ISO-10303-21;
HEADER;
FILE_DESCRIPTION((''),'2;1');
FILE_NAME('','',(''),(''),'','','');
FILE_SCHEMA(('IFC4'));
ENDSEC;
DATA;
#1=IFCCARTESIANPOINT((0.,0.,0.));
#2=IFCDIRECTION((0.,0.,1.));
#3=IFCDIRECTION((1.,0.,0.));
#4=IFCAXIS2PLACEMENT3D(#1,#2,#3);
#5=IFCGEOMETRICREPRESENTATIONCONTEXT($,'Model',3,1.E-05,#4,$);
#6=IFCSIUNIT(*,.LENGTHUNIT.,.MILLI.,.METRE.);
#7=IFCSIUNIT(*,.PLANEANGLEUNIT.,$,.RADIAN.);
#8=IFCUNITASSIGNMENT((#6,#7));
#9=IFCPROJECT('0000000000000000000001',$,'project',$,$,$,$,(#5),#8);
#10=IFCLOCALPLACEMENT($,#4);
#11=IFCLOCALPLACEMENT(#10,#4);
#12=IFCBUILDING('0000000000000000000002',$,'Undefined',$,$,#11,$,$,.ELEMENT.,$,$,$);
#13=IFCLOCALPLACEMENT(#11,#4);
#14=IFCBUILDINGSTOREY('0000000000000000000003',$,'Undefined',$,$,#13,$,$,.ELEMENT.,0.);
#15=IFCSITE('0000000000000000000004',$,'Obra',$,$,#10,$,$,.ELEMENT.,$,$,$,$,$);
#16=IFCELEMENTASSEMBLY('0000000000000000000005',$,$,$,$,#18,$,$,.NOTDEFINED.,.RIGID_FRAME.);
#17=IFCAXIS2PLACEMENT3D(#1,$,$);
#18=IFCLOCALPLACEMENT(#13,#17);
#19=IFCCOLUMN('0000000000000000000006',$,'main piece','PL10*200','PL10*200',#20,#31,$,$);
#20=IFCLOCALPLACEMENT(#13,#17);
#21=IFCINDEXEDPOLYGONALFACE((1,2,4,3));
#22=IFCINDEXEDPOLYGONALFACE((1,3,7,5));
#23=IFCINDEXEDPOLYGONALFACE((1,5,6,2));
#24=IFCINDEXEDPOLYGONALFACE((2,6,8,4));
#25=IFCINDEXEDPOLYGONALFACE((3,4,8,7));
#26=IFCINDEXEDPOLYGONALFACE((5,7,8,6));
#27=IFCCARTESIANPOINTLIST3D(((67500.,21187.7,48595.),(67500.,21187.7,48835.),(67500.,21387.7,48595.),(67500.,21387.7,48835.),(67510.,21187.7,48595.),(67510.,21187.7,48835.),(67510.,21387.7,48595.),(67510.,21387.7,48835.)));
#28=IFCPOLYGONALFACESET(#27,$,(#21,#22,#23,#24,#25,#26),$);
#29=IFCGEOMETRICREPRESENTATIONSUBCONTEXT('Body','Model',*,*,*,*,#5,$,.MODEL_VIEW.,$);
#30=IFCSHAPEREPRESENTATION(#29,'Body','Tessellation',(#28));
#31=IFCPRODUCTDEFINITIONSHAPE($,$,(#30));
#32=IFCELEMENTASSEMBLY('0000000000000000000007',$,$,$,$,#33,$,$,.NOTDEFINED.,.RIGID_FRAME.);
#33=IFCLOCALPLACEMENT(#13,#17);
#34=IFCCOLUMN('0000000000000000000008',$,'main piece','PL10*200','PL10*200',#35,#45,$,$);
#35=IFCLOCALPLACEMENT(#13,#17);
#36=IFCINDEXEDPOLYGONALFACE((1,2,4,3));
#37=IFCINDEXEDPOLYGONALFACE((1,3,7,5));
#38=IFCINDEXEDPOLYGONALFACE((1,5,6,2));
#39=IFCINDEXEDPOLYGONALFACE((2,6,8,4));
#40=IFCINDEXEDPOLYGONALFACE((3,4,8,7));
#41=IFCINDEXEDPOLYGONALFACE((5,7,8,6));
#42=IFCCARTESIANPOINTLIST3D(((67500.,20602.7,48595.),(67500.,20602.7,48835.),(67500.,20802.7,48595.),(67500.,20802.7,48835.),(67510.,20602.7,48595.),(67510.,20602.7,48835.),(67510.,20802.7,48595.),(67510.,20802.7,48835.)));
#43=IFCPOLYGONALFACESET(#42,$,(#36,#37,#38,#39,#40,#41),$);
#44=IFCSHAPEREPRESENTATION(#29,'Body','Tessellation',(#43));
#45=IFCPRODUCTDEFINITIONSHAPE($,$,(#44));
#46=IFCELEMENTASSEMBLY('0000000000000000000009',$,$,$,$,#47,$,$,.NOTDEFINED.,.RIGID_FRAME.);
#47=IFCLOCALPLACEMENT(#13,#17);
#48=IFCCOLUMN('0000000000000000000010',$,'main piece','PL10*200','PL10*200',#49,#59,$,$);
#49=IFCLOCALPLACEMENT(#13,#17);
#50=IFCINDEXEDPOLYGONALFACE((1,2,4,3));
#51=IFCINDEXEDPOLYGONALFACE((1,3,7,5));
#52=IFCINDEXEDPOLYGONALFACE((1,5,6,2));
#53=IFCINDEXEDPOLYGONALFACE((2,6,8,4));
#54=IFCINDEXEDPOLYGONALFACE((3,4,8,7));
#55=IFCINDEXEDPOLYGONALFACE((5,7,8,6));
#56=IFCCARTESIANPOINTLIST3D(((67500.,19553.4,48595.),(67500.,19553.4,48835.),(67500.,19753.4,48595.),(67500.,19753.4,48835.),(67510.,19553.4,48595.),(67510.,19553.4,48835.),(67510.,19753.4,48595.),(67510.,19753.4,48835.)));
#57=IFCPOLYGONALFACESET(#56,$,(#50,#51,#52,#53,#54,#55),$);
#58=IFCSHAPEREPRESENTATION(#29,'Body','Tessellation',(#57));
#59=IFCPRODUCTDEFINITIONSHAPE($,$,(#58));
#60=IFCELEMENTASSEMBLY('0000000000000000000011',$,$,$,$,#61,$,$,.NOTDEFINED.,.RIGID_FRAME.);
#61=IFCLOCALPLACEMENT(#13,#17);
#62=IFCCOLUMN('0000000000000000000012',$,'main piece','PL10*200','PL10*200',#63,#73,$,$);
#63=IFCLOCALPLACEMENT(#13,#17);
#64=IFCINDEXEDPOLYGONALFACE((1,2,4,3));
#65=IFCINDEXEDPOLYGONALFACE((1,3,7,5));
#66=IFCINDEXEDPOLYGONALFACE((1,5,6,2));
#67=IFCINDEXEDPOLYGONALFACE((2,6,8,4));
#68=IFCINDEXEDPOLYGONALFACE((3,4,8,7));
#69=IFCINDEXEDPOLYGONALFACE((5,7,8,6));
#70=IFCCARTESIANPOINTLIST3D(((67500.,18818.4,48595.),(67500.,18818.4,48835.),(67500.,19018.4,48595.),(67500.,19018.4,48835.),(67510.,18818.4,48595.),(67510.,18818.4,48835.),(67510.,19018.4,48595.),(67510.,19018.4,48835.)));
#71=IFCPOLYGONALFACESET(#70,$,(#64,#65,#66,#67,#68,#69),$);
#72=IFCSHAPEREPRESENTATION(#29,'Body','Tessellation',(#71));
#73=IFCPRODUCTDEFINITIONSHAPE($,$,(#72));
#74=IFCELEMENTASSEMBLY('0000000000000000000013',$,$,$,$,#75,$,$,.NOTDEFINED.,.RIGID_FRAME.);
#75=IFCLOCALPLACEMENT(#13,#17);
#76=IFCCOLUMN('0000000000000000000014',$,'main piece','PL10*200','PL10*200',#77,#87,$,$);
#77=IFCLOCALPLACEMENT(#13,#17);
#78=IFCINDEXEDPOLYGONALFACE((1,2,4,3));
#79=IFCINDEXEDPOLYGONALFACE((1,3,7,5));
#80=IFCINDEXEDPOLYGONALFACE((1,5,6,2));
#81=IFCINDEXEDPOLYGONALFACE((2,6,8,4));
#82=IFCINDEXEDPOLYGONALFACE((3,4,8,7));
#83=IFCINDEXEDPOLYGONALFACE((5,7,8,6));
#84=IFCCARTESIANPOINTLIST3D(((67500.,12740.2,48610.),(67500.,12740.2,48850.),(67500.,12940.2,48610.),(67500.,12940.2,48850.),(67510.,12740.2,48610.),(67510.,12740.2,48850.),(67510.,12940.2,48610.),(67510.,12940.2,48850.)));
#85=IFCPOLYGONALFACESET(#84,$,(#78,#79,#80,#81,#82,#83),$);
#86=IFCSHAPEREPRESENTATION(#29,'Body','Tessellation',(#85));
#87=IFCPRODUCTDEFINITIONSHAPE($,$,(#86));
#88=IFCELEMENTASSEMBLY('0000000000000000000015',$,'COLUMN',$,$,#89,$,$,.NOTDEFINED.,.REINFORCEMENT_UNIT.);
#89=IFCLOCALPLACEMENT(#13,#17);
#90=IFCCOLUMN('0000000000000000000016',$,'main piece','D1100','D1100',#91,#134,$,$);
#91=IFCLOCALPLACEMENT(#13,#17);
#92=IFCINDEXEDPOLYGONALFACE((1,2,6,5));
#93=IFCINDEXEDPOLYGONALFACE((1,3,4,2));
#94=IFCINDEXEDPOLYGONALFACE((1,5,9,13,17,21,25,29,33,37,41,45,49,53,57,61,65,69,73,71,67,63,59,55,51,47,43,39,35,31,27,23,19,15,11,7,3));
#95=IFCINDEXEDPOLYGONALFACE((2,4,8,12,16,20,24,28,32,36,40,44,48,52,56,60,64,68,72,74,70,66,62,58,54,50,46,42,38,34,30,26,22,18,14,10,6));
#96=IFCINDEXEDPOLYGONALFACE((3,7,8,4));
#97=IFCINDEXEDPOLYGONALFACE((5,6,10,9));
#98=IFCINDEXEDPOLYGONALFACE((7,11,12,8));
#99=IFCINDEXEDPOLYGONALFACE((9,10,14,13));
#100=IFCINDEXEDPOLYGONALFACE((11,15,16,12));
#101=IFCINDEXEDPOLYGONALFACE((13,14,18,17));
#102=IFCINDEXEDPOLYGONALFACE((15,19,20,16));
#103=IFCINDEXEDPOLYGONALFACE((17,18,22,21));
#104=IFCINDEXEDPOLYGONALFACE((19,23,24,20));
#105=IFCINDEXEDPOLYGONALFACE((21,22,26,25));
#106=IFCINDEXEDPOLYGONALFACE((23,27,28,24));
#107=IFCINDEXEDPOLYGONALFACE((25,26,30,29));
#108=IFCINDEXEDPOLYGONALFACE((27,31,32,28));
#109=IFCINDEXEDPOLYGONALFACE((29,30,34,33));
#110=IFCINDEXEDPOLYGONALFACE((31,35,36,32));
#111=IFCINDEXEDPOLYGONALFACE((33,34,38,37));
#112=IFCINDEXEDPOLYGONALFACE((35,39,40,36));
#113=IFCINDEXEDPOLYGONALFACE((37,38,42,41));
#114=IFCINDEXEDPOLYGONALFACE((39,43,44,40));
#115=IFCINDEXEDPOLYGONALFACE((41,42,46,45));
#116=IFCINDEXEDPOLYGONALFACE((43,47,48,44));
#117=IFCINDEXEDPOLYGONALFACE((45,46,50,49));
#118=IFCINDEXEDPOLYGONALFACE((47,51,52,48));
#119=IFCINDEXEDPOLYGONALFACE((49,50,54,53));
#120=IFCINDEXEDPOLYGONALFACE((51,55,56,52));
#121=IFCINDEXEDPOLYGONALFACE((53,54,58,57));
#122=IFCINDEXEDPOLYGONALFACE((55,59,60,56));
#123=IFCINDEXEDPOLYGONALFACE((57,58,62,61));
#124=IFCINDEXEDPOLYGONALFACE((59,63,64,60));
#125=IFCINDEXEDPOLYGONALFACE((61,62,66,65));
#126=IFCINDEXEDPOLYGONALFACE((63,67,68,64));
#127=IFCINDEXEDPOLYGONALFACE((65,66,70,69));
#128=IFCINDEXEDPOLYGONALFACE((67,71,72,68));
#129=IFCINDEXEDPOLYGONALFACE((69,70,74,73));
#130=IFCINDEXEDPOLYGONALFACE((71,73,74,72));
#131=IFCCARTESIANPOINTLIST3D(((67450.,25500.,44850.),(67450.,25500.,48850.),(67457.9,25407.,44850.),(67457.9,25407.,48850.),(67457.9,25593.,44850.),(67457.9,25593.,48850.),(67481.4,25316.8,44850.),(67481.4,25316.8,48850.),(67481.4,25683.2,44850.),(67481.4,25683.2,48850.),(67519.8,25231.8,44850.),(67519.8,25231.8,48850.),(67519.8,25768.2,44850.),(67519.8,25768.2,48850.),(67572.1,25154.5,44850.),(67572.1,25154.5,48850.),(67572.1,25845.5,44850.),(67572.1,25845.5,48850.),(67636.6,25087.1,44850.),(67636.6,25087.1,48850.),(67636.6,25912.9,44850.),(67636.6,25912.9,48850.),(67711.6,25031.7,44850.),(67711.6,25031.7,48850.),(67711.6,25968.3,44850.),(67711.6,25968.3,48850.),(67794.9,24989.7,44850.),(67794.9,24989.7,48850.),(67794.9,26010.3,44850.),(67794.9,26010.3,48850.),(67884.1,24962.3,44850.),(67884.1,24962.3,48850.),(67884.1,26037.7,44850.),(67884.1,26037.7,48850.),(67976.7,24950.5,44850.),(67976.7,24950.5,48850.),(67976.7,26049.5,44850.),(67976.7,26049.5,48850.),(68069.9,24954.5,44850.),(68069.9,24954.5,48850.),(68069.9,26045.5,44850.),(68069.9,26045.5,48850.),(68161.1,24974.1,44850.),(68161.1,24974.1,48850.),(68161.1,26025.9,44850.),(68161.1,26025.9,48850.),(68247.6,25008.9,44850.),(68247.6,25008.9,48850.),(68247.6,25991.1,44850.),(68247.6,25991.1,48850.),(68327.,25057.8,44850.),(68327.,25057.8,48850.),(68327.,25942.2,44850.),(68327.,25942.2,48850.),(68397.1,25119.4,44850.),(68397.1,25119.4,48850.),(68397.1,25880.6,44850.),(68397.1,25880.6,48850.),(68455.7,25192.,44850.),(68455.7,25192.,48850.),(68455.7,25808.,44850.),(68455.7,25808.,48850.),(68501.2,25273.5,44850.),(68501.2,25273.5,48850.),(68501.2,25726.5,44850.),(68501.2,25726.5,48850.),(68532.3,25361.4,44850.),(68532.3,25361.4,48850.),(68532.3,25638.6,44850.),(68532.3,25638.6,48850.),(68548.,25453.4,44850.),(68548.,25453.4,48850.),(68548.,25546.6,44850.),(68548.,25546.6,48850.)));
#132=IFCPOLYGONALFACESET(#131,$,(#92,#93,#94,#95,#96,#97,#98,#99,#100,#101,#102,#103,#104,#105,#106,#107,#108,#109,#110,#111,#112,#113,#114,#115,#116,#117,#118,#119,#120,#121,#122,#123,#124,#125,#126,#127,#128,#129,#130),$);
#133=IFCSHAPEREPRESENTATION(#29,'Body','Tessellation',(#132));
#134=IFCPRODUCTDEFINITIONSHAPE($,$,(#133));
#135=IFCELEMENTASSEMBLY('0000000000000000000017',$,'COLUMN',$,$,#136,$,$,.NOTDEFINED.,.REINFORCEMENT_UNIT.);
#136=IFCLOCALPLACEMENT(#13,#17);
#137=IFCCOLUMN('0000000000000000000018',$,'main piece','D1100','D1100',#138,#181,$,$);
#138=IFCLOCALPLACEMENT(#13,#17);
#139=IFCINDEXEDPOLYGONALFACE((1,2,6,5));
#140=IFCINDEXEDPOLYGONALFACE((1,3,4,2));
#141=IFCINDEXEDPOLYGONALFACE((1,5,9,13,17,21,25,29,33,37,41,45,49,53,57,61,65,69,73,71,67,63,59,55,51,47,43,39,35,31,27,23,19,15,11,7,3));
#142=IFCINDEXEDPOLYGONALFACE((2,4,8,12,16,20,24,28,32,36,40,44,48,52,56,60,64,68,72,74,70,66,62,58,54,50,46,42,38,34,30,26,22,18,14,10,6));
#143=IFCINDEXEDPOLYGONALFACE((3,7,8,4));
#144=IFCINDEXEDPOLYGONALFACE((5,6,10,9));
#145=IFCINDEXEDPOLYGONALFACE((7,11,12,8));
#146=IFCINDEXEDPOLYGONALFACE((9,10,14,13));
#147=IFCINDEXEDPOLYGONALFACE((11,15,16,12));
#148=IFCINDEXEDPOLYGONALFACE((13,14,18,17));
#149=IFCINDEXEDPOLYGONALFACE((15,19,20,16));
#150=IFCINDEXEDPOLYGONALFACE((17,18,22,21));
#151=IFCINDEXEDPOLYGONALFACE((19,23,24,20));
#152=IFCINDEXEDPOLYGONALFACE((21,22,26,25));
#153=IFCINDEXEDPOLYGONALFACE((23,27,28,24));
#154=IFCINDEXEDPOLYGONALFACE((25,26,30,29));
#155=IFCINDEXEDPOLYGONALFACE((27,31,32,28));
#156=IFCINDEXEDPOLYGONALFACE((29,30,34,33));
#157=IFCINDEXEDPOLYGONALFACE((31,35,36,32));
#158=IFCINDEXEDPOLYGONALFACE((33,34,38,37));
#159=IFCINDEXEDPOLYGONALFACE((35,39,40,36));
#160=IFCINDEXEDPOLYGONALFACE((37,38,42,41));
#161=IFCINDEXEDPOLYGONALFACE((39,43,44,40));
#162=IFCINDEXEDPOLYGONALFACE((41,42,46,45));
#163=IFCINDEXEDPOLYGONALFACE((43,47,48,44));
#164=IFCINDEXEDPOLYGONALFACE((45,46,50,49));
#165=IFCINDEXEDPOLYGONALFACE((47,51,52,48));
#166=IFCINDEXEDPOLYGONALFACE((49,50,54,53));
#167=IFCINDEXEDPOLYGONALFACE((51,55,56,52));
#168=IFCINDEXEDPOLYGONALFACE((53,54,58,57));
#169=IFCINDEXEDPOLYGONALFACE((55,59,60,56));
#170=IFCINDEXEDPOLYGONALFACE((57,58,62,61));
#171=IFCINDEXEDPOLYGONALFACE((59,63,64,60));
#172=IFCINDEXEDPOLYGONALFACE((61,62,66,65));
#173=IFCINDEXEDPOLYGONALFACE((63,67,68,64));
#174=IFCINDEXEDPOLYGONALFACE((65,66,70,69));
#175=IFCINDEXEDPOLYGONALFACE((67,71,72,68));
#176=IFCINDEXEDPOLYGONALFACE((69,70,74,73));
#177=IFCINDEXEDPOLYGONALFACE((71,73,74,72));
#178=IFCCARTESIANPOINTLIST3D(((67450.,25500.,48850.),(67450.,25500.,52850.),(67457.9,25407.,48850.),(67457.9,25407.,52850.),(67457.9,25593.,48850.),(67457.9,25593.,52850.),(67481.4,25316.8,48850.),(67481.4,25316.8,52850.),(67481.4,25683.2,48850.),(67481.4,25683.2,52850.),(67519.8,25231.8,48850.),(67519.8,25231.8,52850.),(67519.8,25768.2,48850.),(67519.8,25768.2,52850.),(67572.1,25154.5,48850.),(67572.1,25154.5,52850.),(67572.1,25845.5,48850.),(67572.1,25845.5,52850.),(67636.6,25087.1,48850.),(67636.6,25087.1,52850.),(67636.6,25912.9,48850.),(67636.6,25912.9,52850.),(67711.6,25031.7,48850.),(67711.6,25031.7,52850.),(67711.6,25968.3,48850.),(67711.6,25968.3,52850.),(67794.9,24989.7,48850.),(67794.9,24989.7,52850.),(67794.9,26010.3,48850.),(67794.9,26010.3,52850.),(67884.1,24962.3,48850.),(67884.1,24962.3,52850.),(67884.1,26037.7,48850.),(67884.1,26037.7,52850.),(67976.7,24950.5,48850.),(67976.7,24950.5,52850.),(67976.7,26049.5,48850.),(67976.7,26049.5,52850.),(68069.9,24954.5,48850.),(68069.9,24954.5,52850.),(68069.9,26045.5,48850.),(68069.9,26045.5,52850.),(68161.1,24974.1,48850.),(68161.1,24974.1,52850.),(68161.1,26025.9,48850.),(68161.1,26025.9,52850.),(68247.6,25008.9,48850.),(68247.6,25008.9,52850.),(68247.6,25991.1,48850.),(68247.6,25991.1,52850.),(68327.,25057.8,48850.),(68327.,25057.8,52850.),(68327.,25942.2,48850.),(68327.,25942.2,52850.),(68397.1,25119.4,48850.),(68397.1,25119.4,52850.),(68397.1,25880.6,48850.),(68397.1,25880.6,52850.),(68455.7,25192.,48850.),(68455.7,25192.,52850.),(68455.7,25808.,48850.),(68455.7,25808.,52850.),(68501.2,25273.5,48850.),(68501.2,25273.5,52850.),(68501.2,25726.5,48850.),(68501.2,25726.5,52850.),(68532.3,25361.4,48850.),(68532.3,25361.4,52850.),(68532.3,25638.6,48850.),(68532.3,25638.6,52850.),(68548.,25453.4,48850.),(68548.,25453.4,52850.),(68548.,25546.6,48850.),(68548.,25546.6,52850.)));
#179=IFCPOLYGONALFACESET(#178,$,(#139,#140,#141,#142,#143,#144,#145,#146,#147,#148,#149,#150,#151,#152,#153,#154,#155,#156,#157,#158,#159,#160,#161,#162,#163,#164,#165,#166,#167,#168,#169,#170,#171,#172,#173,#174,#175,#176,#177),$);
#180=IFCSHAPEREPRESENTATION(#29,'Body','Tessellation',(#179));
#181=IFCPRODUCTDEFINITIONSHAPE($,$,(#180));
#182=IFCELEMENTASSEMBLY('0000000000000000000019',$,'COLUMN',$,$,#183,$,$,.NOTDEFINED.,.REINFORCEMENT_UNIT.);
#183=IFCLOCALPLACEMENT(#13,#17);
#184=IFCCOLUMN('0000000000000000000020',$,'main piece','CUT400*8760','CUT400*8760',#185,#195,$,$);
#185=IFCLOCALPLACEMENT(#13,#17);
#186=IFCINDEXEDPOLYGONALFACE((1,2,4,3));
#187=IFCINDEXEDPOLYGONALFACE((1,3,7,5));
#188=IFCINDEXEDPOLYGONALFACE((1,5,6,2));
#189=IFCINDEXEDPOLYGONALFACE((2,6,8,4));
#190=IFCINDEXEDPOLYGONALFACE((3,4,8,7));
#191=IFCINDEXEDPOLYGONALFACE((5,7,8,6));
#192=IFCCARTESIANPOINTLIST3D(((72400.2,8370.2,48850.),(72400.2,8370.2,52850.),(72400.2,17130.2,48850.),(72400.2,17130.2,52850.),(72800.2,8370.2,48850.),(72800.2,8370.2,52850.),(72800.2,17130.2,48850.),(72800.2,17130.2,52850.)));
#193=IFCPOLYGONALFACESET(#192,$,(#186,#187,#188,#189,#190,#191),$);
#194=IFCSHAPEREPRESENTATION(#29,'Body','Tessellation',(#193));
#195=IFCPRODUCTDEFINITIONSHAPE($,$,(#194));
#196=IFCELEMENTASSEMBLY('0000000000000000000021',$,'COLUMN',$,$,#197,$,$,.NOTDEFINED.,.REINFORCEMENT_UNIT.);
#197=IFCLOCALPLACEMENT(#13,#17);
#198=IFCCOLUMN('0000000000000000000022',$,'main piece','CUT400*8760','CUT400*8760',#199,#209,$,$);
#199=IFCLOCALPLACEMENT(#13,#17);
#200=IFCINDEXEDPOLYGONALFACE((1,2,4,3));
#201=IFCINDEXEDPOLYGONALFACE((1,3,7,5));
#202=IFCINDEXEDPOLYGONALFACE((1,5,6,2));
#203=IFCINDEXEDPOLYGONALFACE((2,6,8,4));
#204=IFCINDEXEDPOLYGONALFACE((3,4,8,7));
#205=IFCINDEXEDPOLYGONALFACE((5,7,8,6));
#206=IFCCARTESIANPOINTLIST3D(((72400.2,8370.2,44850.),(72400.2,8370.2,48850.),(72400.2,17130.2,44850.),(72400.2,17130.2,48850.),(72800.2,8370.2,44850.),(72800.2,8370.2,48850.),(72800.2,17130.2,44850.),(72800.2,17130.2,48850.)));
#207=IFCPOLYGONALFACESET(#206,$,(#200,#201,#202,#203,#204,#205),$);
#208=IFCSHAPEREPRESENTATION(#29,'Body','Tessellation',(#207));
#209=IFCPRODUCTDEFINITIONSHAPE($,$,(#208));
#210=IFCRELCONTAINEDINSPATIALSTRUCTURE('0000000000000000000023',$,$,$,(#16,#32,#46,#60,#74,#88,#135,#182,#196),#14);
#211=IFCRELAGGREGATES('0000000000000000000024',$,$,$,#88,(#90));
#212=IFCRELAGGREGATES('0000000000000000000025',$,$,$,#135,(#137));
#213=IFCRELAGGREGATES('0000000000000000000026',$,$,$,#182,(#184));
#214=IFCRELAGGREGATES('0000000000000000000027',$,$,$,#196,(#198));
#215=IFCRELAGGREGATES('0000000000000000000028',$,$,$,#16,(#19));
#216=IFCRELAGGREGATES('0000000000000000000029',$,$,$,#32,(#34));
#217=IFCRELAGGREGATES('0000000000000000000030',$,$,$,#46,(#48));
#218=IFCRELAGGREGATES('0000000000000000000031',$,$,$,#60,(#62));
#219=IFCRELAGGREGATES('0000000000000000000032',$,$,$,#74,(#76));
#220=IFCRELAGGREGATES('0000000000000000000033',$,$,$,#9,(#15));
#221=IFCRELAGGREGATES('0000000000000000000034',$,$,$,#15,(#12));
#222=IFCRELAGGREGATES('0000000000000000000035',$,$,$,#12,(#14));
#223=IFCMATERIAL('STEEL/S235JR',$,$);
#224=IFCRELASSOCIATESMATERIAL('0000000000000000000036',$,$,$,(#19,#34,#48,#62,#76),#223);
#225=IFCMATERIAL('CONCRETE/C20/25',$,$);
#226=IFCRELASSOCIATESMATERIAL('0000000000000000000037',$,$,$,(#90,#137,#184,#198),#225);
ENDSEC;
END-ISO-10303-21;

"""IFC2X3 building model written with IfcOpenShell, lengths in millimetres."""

from ifc_helpers import new_model, si_unit, frame, origin_with_axes, origin_2d_with_axis, place, context, subcontext, project, spatial, rectangle, circle, extrude, material, element, aggregate, save


model = new_model("IFC2X3")

# Units and contexts
model_context = context("Model", 3, precision=1e-05, world=origin_with_axes())
body_context = subcontext(model_context, "Body", "Model", "MODEL_VIEW")
ifc_project = project(units=[si_unit("LENGTHUNIT", "METRE", prefix="MILLI"), si_unit("PLANEANGLEUNIT", "RADIAN")], contexts=[model_context])

# Site, building, storey
site_placement = place(None, origin_with_axes())
site = spatial("IfcSite", under=ifc_project, at=site_placement, Name="Obra", CompositionType="ELEMENT")
building_placement = place(site_placement, origin_with_axes())
building = spatial("IfcBuilding", under=site, at=building_placement, Name="Undefined", CompositionType="ELEMENT")
storey_placement = place(building_placement, origin_with_axes())
storey = spatial("IfcBuildingStorey", under=building, at=storey_placement, Name="Undefined", CompositionType="ELEMENT", Elevation=0.0)

# Element assemblies, columns
assembly_1_placement = place(storey_placement, origin_with_axes())
assembly_1 = element("IfcElementAssembly", 1, at=assembly_1_placement, inside=storey, AssemblyPlace="NOTDEFINED", PredefinedType="RIGID_FRAME")
ifc_material_1 = material(Name="STEEL/S235JR")
column_1_placement = place(assembly_1_placement, frame((67505.0, 21287.7, 48595.0), z_axis=(0.0, 0.0, 1.0), x_axis=(0.0, 1.0, 0.0)))
column_1 = element("IfcColumn", 2, at=column_1_placement, material=ifc_material_1, Name="main piece", Description="PL10*200", ObjectType="PL10*200", context=body_context, shape_type="SweptSolid", body=[
    extrude(rectangle(XDim=10.0, YDim=200.0, at=origin_2d_with_axis()), frame((0.0, 0.0, 240.0), z_axis=(0.0, 0.0, -1.0), x_axis=(0.0, 1.0, 0.0)), (0.0, 0.0, 1.0), 240.0),
])
assembly_2_placement = place(storey_placement, origin_with_axes())
assembly_2 = element("IfcElementAssembly", 3, at=assembly_2_placement, inside=storey, AssemblyPlace="NOTDEFINED", PredefinedType="RIGID_FRAME")
column_2_placement = place(assembly_2_placement, frame((67505.0, 20702.7, 48595.0), z_axis=(0.0, 0.0, 1.0), x_axis=(0.0, 1.0, 0.0)))
column_2 = element("IfcColumn", 4, at=column_2_placement, material=ifc_material_1, Name="main piece", Description="PL10*200", ObjectType="PL10*200", context=body_context, shape_type="SweptSolid", body=[
    extrude(rectangle(XDim=10.0, YDim=200.0, at=origin_2d_with_axis()), frame((0.0, 0.0, 240.0), z_axis=(0.0, 0.0, -1.0), x_axis=(0.0, 1.0, 0.0)), (0.0, 0.0, 1.0), 240.0),
])
assembly_3_placement = place(storey_placement, origin_with_axes())
assembly_3 = element("IfcElementAssembly", 5, at=assembly_3_placement, inside=storey, AssemblyPlace="NOTDEFINED", PredefinedType="RIGID_FRAME")
column_3_placement = place(assembly_3_placement, frame((67505.0, 19653.4, 48595.0), z_axis=(0.0, 0.0, 1.0), x_axis=(0.0, 1.0, 0.0)))
column_3 = element("IfcColumn", 6, at=column_3_placement, material=ifc_material_1, Name="main piece", Description="PL10*200", ObjectType="PL10*200", context=body_context, shape_type="SweptSolid", body=[
    extrude(rectangle(XDim=10.0, YDim=200.0, at=origin_2d_with_axis()), frame((0.0, 0.0, 240.0), z_axis=(0.0, 0.0, -1.0), x_axis=(0.0, 1.0, 0.0)), (0.0, 0.0, 1.0), 240.0),
])
assembly_4_placement = place(storey_placement, origin_with_axes())
assembly_4 = element("IfcElementAssembly", 7, at=assembly_4_placement, inside=storey, AssemblyPlace="NOTDEFINED", PredefinedType="RIGID_FRAME")
column_4_placement = place(assembly_4_placement, frame((67505.0, 18918.4, 48595.0), z_axis=(0.0, 0.0, 1.0), x_axis=(0.0, 1.0, 0.0)))
column_4 = element("IfcColumn", 8, at=column_4_placement, material=ifc_material_1, Name="main piece", Description="PL10*200", ObjectType="PL10*200", context=body_context, shape_type="SweptSolid", body=[
    extrude(rectangle(XDim=10.0, YDim=200.0, at=origin_2d_with_axis()), frame((0.0, 0.0, 240.0), z_axis=(0.0, 0.0, -1.0), x_axis=(0.0, 1.0, 0.0)), (0.0, 0.0, 1.0), 240.0),
])
assembly_5_placement = place(storey_placement, origin_with_axes())
assembly_5 = element("IfcElementAssembly", 9, at=assembly_5_placement, inside=storey, AssemblyPlace="NOTDEFINED", PredefinedType="RIGID_FRAME")
column_5_placement = place(assembly_5_placement, frame((67505.0, 12840.2, 48610.0), z_axis=(0.0, 0.0, 1.0), x_axis=(0.0, 1.0, 0.0)))
column_5 = element("IfcColumn", 10, at=column_5_placement, material=ifc_material_1, Name="main piece", Description="PL10*200", ObjectType="PL10*200", context=body_context, shape_type="SweptSolid", body=[
    extrude(rectangle(XDim=10.0, YDim=200.0, at=origin_2d_with_axis()), frame((0.0, 0.0, 240.0), z_axis=(0.0, 0.0, -1.0), x_axis=(0.0, 1.0, 0.0)), (0.0, 0.0, 1.0), 240.0),
])
assembly_6_placement = place(storey_placement, origin_with_axes())
assembly_6 = element("IfcElementAssembly", 11, at=assembly_6_placement, inside=storey, Name="COLUMN", AssemblyPlace="NOTDEFINED", PredefinedType="REINFORCEMENT_UNIT")
ifc_material_2 = material(Name="CONCRETE/C20/25")
column_6_placement = place(assembly_6_placement, frame((68000.0, 25500.0, 44850.0), z_axis=(0.0, 0.0, 1.0), x_axis=(0.0, 1.0, 0.0)))
column_6 = element("IfcColumn", 12, at=column_6_placement, material=ifc_material_2, Name="main piece", Description="D1100", ObjectType="D1100", context=body_context, shape_type="SweptSolid", body=[
    extrude(circle(Radius=550.0, at=origin_2d_with_axis()), frame((0.0, 0.0, 4000.0), z_axis=(0.0, 0.0, -1.0), x_axis=(0.0, 1.0, 0.0)), (0.0, 0.0, 1.0), 4000.0),
])
aggregate(assembly_6, [column_6])
assembly_7_placement = place(storey_placement, origin_with_axes())
assembly_7 = element("IfcElementAssembly", 13, at=assembly_7_placement, inside=storey, Name="COLUMN", AssemblyPlace="NOTDEFINED", PredefinedType="REINFORCEMENT_UNIT")
column_7_placement = place(assembly_7_placement, frame((68000.0, 25500.0, 48850.0), z_axis=(0.0, 0.0, 1.0), x_axis=(0.0, 1.0, 0.0)))
column_7 = element("IfcColumn", 14, at=column_7_placement, material=ifc_material_2, Name="main piece", Description="D1100", ObjectType="D1100", context=body_context, shape_type="SweptSolid", body=[
    extrude(circle(Radius=550.0, at=origin_2d_with_axis()), frame((0.0, 0.0, 4000.0), z_axis=(0.0, 0.0, -1.0), x_axis=(0.0, 1.0, 0.0)), (0.0, 0.0, 1.0), 4000.0),
])
aggregate(assembly_7, [column_7])
assembly_8_placement = place(storey_placement, origin_with_axes())
assembly_8 = element("IfcElementAssembly", 15, at=assembly_8_placement, inside=storey, Name="COLUMN", AssemblyPlace="NOTDEFINED", PredefinedType="REINFORCEMENT_UNIT")
column_8_placement = place(assembly_8_placement, frame((72600.2, 12750.2, 48850.0), z_axis=(0.0, 0.0, 1.0), x_axis=(0.0, -1.0, 0.0)))
column_8 = element("IfcColumn", 16, at=column_8_placement, material=ifc_material_2, Name="main piece", Description="CUT400*8760", ObjectType="CUT400*8760", context=body_context, shape_type="SweptSolid", body=[
    extrude(rectangle(XDim=400.0, YDim=8760.0, at=origin_2d_with_axis()), frame((0.0, 0.0, 4000.0), z_axis=(0.0, 0.0, -1.0), x_axis=(0.0, 1.0, 0.0)), (0.0, 0.0, 1.0), 4000.0),
])
aggregate(assembly_8, [column_8])
assembly_9_placement = place(storey_placement, origin_with_axes())
assembly_9 = element("IfcElementAssembly", 17, at=assembly_9_placement, inside=storey, Name="COLUMN", AssemblyPlace="NOTDEFINED", PredefinedType="REINFORCEMENT_UNIT")
column_9_placement = place(assembly_9_placement, frame((72600.2, 12750.2, 44850.0), z_axis=(0.0, 0.0, 1.0), x_axis=(0.0, -1.0, 0.0)))
column_9 = element("IfcColumn", 18, at=column_9_placement, material=ifc_material_2, Name="main piece", Description="CUT400*8760", ObjectType="CUT400*8760", context=body_context, shape_type="SweptSolid", body=[
    extrude(rectangle(XDim=400.0, YDim=8760.0, at=origin_2d_with_axis()), frame((0.0, 0.0, 4000.0), z_axis=(0.0, 0.0, -1.0), x_axis=(0.0, 1.0, 0.0)), (0.0, 0.0, 1.0), 4000.0),
])
aggregate(assembly_9, [column_9])

aggregate(assembly_1, [column_1])
aggregate(assembly_2, [column_2])
aggregate(assembly_3, [column_3])
aggregate(assembly_4, [column_4])
aggregate(assembly_5, [column_5])

save(model, "model.ifc")
